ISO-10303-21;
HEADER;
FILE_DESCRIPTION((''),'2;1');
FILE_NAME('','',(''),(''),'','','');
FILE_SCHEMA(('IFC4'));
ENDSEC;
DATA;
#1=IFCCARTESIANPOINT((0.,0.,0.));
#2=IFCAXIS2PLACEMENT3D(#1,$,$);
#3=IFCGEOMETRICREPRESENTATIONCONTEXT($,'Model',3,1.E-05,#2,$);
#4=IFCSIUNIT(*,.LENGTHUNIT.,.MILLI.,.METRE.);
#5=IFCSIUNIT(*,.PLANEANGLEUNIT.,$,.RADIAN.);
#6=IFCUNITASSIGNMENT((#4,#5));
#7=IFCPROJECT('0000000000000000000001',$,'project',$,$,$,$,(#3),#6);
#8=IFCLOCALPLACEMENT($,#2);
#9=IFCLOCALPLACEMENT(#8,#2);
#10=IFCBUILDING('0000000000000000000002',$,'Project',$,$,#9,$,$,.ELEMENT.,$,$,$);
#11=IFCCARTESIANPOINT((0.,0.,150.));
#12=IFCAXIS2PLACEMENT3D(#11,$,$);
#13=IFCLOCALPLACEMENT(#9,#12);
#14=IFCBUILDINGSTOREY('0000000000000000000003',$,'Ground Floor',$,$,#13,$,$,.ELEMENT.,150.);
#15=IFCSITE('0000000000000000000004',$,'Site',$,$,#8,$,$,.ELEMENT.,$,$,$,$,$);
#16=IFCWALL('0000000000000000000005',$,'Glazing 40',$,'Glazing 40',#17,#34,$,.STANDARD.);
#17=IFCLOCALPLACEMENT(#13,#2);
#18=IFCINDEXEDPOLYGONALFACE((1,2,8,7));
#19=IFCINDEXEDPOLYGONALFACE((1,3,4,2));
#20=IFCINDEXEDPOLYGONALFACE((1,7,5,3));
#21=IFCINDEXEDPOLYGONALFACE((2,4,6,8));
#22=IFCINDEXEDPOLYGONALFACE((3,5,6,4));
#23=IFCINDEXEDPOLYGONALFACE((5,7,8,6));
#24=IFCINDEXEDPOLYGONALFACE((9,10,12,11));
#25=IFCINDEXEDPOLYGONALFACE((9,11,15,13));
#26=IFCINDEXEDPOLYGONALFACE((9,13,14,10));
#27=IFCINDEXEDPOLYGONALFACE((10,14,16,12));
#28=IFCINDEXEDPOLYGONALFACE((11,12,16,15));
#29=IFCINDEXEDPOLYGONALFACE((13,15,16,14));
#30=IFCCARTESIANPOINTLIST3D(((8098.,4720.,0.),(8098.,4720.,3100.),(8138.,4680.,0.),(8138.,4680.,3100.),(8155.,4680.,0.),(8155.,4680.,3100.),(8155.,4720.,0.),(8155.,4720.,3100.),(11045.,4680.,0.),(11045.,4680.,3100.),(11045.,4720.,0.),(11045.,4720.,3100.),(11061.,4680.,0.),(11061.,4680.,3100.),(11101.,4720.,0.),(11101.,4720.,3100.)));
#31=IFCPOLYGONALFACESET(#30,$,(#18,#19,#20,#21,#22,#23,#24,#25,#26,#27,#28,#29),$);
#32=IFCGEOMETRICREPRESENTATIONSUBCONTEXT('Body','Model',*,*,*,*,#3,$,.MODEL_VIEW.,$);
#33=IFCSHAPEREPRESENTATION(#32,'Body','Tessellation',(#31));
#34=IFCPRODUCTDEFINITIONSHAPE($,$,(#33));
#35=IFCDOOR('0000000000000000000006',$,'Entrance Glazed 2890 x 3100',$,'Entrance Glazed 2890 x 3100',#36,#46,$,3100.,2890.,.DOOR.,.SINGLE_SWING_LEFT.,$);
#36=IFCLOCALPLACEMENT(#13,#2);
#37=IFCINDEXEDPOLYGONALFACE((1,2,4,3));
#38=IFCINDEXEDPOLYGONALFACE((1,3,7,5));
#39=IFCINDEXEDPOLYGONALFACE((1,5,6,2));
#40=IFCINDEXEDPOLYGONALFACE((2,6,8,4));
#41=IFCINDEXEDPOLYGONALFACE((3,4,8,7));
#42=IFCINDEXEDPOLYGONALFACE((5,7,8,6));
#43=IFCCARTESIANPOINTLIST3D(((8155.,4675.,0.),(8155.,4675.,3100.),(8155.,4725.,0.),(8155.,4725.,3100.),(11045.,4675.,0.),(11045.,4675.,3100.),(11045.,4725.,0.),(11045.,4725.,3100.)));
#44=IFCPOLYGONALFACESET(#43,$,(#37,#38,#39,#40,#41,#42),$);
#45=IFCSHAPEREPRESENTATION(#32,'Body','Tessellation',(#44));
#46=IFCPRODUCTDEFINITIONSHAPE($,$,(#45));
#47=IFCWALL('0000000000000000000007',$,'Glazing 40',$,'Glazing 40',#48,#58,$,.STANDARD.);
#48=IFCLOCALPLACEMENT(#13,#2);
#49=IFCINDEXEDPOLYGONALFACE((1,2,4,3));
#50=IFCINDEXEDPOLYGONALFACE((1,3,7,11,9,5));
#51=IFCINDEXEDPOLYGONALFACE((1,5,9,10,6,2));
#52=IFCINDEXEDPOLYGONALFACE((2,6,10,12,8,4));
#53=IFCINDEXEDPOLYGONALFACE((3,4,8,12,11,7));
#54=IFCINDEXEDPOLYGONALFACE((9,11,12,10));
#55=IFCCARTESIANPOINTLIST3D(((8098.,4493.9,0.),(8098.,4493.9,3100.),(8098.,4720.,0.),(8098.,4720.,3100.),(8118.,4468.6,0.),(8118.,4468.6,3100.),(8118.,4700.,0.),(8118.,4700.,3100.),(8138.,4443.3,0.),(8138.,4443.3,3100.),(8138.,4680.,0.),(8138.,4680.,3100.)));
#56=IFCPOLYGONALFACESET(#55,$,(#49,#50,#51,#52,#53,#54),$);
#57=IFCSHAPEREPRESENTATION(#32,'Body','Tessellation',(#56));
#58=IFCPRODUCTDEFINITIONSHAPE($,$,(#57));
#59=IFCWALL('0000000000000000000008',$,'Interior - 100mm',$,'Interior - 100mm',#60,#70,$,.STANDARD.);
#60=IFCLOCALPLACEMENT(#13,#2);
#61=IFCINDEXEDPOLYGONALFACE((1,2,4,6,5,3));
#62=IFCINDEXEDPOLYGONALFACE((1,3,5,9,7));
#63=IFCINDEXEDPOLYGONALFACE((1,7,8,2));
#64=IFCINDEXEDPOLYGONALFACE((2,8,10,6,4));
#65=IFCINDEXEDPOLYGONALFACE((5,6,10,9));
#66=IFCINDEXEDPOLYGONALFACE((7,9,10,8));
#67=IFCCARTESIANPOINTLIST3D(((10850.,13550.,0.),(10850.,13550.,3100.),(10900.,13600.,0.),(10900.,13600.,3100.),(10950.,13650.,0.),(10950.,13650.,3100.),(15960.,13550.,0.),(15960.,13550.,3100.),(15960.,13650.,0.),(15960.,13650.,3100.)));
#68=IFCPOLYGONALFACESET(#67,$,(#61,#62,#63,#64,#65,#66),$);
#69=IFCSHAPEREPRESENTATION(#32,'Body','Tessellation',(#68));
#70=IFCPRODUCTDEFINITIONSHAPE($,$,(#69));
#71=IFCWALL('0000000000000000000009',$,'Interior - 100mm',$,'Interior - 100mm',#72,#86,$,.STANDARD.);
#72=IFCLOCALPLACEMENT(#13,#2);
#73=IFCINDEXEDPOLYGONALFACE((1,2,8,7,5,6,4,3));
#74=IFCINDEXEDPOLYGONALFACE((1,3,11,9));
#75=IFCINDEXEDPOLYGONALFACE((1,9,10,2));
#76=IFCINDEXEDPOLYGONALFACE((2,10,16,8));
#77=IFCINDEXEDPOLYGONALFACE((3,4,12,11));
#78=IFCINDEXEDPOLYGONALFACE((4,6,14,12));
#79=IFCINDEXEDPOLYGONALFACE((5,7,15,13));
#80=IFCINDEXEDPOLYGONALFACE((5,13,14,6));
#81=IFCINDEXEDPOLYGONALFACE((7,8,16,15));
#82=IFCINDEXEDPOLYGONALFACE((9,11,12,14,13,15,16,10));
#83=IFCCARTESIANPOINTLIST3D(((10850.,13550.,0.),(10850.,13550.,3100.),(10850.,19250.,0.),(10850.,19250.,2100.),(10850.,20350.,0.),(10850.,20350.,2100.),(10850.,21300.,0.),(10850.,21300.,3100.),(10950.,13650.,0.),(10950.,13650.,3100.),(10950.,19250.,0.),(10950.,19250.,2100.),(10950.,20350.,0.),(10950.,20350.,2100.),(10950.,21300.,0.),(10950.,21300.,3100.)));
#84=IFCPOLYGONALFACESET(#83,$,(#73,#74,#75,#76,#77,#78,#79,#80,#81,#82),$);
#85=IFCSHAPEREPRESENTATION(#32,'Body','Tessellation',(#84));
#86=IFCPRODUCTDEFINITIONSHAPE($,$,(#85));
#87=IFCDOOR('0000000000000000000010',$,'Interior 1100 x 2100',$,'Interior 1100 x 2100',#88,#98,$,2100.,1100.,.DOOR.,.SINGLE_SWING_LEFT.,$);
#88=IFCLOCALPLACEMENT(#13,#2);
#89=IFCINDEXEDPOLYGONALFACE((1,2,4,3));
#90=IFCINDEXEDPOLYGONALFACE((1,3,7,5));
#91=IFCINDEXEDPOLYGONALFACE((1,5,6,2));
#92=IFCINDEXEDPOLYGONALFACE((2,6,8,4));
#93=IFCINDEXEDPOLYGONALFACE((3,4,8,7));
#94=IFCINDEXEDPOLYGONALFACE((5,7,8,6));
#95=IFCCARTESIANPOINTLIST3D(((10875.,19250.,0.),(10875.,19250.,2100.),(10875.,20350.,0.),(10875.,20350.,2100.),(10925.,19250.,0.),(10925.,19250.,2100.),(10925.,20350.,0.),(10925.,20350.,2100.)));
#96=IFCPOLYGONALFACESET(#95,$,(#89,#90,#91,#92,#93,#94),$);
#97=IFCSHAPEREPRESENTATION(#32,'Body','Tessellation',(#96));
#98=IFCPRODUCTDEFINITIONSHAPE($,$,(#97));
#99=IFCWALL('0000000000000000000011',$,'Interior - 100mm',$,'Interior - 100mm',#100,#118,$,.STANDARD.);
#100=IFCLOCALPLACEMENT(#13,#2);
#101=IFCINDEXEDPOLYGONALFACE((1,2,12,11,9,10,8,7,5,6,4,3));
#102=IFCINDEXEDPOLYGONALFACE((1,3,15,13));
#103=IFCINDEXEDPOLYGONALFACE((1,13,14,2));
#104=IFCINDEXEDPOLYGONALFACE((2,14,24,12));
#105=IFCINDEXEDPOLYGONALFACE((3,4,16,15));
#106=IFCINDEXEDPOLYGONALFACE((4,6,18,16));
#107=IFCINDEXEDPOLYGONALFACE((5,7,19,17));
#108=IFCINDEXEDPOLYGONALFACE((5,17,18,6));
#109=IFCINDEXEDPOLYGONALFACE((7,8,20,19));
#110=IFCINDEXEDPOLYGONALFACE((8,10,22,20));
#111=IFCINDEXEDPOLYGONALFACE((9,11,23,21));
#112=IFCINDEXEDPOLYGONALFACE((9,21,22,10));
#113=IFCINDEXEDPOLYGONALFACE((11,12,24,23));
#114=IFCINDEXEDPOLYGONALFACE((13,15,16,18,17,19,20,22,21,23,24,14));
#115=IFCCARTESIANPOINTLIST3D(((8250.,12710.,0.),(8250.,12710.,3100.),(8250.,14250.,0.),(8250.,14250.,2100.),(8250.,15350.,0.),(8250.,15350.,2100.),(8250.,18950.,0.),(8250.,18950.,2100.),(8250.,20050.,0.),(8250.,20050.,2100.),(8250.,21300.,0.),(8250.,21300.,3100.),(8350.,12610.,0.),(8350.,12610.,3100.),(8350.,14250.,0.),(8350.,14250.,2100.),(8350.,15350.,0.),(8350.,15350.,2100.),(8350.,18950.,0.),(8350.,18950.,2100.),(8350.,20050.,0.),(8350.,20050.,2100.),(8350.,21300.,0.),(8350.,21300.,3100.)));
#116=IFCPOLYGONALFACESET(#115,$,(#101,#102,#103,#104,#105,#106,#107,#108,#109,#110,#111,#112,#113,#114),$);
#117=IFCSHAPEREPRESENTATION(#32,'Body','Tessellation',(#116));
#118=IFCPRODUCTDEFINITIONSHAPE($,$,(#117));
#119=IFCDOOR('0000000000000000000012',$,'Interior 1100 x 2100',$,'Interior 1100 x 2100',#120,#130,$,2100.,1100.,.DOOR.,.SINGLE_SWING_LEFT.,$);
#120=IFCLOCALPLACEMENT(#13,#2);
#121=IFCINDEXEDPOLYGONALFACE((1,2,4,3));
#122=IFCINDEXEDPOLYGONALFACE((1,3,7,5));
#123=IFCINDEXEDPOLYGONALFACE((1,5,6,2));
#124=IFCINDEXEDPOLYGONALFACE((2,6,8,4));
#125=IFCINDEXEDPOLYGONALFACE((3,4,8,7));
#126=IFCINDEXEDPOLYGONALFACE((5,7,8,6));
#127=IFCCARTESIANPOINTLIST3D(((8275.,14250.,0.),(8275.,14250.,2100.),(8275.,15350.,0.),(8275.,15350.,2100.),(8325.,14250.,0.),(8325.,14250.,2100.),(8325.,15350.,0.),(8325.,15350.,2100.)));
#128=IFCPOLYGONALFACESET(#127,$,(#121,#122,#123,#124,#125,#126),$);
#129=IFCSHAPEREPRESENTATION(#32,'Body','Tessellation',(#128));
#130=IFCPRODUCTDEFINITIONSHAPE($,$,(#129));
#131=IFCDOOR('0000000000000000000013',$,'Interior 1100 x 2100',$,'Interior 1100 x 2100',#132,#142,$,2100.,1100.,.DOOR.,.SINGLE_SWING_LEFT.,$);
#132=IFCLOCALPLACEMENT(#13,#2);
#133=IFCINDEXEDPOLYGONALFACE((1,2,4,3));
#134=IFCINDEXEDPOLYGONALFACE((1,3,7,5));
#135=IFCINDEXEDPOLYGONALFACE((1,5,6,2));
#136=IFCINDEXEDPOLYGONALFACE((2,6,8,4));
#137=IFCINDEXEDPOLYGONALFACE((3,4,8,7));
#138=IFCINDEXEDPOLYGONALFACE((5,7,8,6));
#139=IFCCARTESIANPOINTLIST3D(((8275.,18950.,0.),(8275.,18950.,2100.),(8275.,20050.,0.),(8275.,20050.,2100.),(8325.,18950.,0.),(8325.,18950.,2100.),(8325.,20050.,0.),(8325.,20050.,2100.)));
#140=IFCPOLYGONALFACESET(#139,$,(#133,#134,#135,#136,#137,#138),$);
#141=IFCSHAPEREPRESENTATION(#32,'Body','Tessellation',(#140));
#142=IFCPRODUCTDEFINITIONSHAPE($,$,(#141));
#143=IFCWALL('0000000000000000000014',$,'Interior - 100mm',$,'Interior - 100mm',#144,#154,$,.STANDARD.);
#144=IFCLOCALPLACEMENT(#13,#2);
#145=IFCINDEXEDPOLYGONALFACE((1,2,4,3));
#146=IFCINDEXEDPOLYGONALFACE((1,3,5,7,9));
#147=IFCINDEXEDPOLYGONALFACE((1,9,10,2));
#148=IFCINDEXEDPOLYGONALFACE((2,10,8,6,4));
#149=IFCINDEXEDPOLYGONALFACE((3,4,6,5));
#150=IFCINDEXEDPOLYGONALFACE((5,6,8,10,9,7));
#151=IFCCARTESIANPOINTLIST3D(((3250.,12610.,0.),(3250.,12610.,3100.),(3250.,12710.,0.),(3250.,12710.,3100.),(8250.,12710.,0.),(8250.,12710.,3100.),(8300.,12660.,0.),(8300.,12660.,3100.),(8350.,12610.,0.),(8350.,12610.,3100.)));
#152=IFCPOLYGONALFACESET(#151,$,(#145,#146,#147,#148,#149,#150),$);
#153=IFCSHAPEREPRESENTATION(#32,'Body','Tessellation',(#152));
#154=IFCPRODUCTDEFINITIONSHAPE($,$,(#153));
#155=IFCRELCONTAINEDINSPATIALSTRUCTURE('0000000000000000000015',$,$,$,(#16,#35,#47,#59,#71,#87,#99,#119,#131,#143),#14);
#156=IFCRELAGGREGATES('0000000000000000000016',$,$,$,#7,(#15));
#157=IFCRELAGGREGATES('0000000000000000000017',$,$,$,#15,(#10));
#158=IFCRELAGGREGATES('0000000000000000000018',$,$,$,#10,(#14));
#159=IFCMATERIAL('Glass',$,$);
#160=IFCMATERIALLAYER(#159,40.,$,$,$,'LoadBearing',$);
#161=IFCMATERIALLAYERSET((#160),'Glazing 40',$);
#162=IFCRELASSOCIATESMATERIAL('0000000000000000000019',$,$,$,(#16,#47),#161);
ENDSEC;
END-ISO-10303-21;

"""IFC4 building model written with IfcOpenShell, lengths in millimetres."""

from ifc_helpers import new_model, si_unit, frame, frame_2d, origin, place, context, subcontext, project, spatial, polyline, rectangle, outline, extrude, material, layer, layer_set, layer_usage, element, fill, save


model = new_model("IFC4")

# Units and contexts
model_context = context("Model", 3, precision=1e-05, world=origin())
body_context = subcontext(model_context, "Body", "Model", "MODEL_VIEW")
ifc_project = project(units=[si_unit("LENGTHUNIT", "METRE", prefix="MILLI"), si_unit("PLANEANGLEUNIT", "RADIAN")], contexts=[model_context])

# Site, building, storey
site_placement = place(None, origin())
site = spatial("IfcSite", under=ifc_project, at=site_placement, Name="Site", CompositionType="ELEMENT")
building_placement = place(site_placement, origin())
building = spatial("IfcBuilding", under=site, at=building_placement, Name="Project", CompositionType="ELEMENT")
storey_placement = place(building_placement, frame((0.0, 0.0, 150.0)))
storey = spatial("IfcBuildingStorey", under=building, at=storey_placement, Name="Ground Floor", CompositionType="ELEMENT", Elevation=150.0)

# Shared definitions
ifc_material_1 = material(Name="Glass")
ifc_layer_1 = layer(ifc_material_1, 40.0, Category="LoadBearing")
ifc_layer_set_1 = layer_set([ifc_layer_1], Name="Glazing 40")
ifc_layer_usage_1 = layer_usage(ifc_layer_set_1, "AXIS2", "NEGATIVE", 20.0)

# Wall, opening, door
wall_1_placement = place(storey_placement, frame((11081.0, 4700.0, 0.0), z_axis=(0.0, 0.0, 1.0), x_axis=(-1.0, 0.0, 0.0)))
wall_1 = element("IfcWall", 1, at=wall_1_placement, inside=storey, material=ifc_layer_usage_1, Name="Glazing 40", ObjectType="Glazing 40", PredefinedType="STANDARD", context=body_context, shape_type="SweptSolid", body=[
    extrude(outline(polyline([(-20.0, -20.0), (0.0, 0.0), (20.0, 20.0), (2943.0, 20.0), (2963.0, 0.0), (2983.0, -20.0), (-20.0, -20.0)])), origin(), (0.0, 0.0, 1.0), 3100.0),
])
opening_1_placement = place(wall_1_placement, frame((36.0, 0.0, 0.0), z_axis=(0.0, 0.0, 1.0), x_axis=(1.0, 0.0, 0.0)))
opening_1 = element("IfcOpeningElement", 2, at=opening_1_placement, cuts=wall_1, PredefinedType="OPENING", context=body_context, shape_type="SweptSolid", body=[
    extrude(rectangle(XDim=2890.0, YDim=60.0, at=frame_2d((1445.0, 0.0))), origin(), (0.0, 0.0, 1.0), 3100.0),
])
door_1_placement = place(opening_1_placement, origin())
door_1 = element("IfcDoor", 3, at=door_1_placement, inside=storey, Name="Entrance Glazed 2890 x 3100", ObjectType="Entrance Glazed 2890 x 3100", OperationType="SINGLE_SWING_LEFT", OverallHeight=3100.0, OverallWidth=2890.0, PredefinedType="DOOR", context=body_context, shape_type="SweptSolid", body=[
    extrude(rectangle(XDim=2890.0, YDim=50.0, at=frame_2d((1445.0, 0.0))), origin(), (0.0, 0.0, 1.0), 3100.0),
])
fill(opening_1, door_1)

# Walls
wall_2_placement = place(storey_placement, frame((8118.0, 4700.0, 0.0), z_axis=(0.0, 0.0, 1.0), x_axis=(0.0, -1.0, 0.0)))
element("IfcWall", 4, at=wall_2_placement, inside=storey, material=ifc_layer_usage_1, Name="Glazing 40", ObjectType="Glazing 40", PredefinedType="STANDARD", context=body_context, shape_type="SweptSolid", body=[
    extrude(outline(polyline([(-20.0, -20.0), (0.0, 0.0), (20.0, 20.0), (256.7, 20.0), (231.4, 0.0), (206.1, -20.0), (-20.0, -20.0)])), origin(), (0.0, 0.0, 1.0), 3100.0),
])
wall_3_placement = place(storey_placement, frame((10900.0, 13600.0, 0.0), z_axis=(0.0, 0.0, 1.0), x_axis=(1.0, 0.0, 0.0)))
element("IfcWall", 5, at=wall_3_placement, inside=storey, Name="Interior - 100mm", ObjectType="Interior - 100mm", PredefinedType="STANDARD", context=body_context, shape_type="SweptSolid", body=[
    extrude(outline(polyline([(-50.0, -50.0), (0.0, 0.0), (50.0, 50.0), (5060.0, 50.0), (5060.0, -50.0), (-50.0, -50.0)])), origin(), (0.0, 0.0, 1.0), 3100.0),
])

# Wall, opening, door
wall_4_placement = place(storey_placement, frame((10900.0, 13600.0, 0.0), z_axis=(0.0, 0.0, 1.0), x_axis=(0.0, 1.0, 0.0)))
wall_4 = element("IfcWall", 6, at=wall_4_placement, inside=storey, Name="Interior - 100mm", ObjectType="Interior - 100mm", PredefinedType="STANDARD", context=body_context, shape_type="SweptSolid", body=[
    extrude(outline(polyline([(50.0, -50.0), (0.0, 0.0), (-50.0, 50.0), (7700.0, 50.0), (7700.0, -50.0), (50.0, -50.0)])), origin(), (0.0, 0.0, 1.0), 3100.0),
])
opening_2_placement = place(wall_4_placement, frame((5650.0, 0.0, 0.0), z_axis=(0.0, 0.0, 1.0), x_axis=(1.0, 0.0, 0.0)))
opening_2 = element("IfcOpeningElement", 7, at=opening_2_placement, cuts=wall_4, PredefinedType="OPENING", context=body_context, shape_type="SweptSolid", body=[
    extrude(rectangle(XDim=1100.0, YDim=120.0, at=frame_2d((550.0, 0.0))), origin(), (0.0, 0.0, 1.0), 2100.0),
])
door_2_placement = place(opening_2_placement, origin())
door_2 = element("IfcDoor", 8, at=door_2_placement, inside=storey, Name="Interior 1100 x 2100", ObjectType="Interior 1100 x 2100", OperationType="SINGLE_SWING_LEFT", OverallHeight=2100.0, OverallWidth=1100.0, PredefinedType="DOOR", context=body_context, shape_type="SweptSolid", body=[
    extrude(rectangle(XDim=1100.0, YDim=50.0, at=frame_2d((550.0, 0.0))), origin(), (0.0, 0.0, 1.0), 2100.0),
])
fill(opening_2, door_2)

# Wall, openings, doors
wall_5_placement = place(storey_placement, frame((8300.0, 12660.0, 0.0), z_axis=(0.0, 0.0, 1.0), x_axis=(0.0, 1.0, 0.0)))
wall_5 = element("IfcWall", 9, at=wall_5_placement, inside=storey, Name="Interior - 100mm", ObjectType="Interior - 100mm", PredefinedType="STANDARD", context=body_context, shape_type="SweptSolid", body=[
    extrude(outline(polyline([(-50.0, -50.0), (0.0, 0.0), (50.0, 50.0), (8640.0, 50.0), (8640.0, -50.0), (-50.0, -50.0)])), origin(), (0.0, 0.0, 1.0), 3100.0),
])
opening_3_placement = place(wall_5_placement, frame((1590.0, 0.0, 0.0), z_axis=(0.0, 0.0, 1.0), x_axis=(1.0, 0.0, 0.0)))
opening_3 = element("IfcOpeningElement", 10, at=opening_3_placement, cuts=wall_5, PredefinedType="OPENING", context=body_context, shape_type="SweptSolid", body=[
    extrude(rectangle(XDim=1100.0, YDim=120.0, at=frame_2d((550.0, 0.0))), origin(), (0.0, 0.0, 1.0), 2100.0),
])
opening_4_placement = place(wall_5_placement, frame((6290.0, 0.0, 0.0), z_axis=(0.0, 0.0, 1.0), x_axis=(1.0, 0.0, 0.0)))
opening_4 = element("IfcOpeningElement", 11, at=opening_4_placement, cuts=wall_5, PredefinedType="OPENING", context=body_context, shape_type="SweptSolid", body=[
    extrude(rectangle(XDim=1100.0, YDim=120.0, at=frame_2d((550.0, 0.0))), origin(), (0.0, 0.0, 1.0), 2100.0),
])
door_3_placement = place(opening_3_placement, origin())
door_3 = element("IfcDoor", 12, at=door_3_placement, inside=storey, Name="Interior 1100 x 2100", ObjectType="Interior 1100 x 2100", OperationType="SINGLE_SWING_LEFT", OverallHeight=2100.0, OverallWidth=1100.0, PredefinedType="DOOR", context=body_context, shape_type="SweptSolid", body=[
    extrude(rectangle(XDim=1100.0, YDim=50.0, at=frame_2d((550.0, 0.0))), origin(), (0.0, 0.0, 1.0), 2100.0),
])
fill(opening_3, door_3)
door_4_placement = place(opening_4_placement, origin())
door_4 = element("IfcDoor", 13, at=door_4_placement, inside=storey, Name="Interior 1100 x 2100", ObjectType="Interior 1100 x 2100", OperationType="SINGLE_SWING_LEFT", OverallHeight=2100.0, OverallWidth=1100.0, PredefinedType="DOOR", context=body_context, shape_type="SweptSolid", body=[
    extrude(rectangle(XDim=1100.0, YDim=50.0, at=frame_2d((550.0, 0.0))), origin(), (0.0, 0.0, 1.0), 2100.0),
])
fill(opening_4, door_4)

# Wall
wall_6_placement = place(storey_placement, frame((3150.0, 12660.0, 0.0), z_axis=(0.0, 0.0, 1.0), x_axis=(1.0, 0.0, 0.0)))
element("IfcWall", 14, at=wall_6_placement, inside=storey, Name="Interior - 100mm", ObjectType="Interior - 100mm", PredefinedType="STANDARD", context=body_context, shape_type="SweptSolid", body=[
    extrude(outline(polyline([(100.0, -50.0), (100.0, 50.0), (5100.0, 50.0), (5150.0, 0.0), (5200.0, -50.0), (100.0, -50.0)])), origin(), (0.0, 0.0, 1.0), 3100.0),
])

save(model, "model.ifc")
